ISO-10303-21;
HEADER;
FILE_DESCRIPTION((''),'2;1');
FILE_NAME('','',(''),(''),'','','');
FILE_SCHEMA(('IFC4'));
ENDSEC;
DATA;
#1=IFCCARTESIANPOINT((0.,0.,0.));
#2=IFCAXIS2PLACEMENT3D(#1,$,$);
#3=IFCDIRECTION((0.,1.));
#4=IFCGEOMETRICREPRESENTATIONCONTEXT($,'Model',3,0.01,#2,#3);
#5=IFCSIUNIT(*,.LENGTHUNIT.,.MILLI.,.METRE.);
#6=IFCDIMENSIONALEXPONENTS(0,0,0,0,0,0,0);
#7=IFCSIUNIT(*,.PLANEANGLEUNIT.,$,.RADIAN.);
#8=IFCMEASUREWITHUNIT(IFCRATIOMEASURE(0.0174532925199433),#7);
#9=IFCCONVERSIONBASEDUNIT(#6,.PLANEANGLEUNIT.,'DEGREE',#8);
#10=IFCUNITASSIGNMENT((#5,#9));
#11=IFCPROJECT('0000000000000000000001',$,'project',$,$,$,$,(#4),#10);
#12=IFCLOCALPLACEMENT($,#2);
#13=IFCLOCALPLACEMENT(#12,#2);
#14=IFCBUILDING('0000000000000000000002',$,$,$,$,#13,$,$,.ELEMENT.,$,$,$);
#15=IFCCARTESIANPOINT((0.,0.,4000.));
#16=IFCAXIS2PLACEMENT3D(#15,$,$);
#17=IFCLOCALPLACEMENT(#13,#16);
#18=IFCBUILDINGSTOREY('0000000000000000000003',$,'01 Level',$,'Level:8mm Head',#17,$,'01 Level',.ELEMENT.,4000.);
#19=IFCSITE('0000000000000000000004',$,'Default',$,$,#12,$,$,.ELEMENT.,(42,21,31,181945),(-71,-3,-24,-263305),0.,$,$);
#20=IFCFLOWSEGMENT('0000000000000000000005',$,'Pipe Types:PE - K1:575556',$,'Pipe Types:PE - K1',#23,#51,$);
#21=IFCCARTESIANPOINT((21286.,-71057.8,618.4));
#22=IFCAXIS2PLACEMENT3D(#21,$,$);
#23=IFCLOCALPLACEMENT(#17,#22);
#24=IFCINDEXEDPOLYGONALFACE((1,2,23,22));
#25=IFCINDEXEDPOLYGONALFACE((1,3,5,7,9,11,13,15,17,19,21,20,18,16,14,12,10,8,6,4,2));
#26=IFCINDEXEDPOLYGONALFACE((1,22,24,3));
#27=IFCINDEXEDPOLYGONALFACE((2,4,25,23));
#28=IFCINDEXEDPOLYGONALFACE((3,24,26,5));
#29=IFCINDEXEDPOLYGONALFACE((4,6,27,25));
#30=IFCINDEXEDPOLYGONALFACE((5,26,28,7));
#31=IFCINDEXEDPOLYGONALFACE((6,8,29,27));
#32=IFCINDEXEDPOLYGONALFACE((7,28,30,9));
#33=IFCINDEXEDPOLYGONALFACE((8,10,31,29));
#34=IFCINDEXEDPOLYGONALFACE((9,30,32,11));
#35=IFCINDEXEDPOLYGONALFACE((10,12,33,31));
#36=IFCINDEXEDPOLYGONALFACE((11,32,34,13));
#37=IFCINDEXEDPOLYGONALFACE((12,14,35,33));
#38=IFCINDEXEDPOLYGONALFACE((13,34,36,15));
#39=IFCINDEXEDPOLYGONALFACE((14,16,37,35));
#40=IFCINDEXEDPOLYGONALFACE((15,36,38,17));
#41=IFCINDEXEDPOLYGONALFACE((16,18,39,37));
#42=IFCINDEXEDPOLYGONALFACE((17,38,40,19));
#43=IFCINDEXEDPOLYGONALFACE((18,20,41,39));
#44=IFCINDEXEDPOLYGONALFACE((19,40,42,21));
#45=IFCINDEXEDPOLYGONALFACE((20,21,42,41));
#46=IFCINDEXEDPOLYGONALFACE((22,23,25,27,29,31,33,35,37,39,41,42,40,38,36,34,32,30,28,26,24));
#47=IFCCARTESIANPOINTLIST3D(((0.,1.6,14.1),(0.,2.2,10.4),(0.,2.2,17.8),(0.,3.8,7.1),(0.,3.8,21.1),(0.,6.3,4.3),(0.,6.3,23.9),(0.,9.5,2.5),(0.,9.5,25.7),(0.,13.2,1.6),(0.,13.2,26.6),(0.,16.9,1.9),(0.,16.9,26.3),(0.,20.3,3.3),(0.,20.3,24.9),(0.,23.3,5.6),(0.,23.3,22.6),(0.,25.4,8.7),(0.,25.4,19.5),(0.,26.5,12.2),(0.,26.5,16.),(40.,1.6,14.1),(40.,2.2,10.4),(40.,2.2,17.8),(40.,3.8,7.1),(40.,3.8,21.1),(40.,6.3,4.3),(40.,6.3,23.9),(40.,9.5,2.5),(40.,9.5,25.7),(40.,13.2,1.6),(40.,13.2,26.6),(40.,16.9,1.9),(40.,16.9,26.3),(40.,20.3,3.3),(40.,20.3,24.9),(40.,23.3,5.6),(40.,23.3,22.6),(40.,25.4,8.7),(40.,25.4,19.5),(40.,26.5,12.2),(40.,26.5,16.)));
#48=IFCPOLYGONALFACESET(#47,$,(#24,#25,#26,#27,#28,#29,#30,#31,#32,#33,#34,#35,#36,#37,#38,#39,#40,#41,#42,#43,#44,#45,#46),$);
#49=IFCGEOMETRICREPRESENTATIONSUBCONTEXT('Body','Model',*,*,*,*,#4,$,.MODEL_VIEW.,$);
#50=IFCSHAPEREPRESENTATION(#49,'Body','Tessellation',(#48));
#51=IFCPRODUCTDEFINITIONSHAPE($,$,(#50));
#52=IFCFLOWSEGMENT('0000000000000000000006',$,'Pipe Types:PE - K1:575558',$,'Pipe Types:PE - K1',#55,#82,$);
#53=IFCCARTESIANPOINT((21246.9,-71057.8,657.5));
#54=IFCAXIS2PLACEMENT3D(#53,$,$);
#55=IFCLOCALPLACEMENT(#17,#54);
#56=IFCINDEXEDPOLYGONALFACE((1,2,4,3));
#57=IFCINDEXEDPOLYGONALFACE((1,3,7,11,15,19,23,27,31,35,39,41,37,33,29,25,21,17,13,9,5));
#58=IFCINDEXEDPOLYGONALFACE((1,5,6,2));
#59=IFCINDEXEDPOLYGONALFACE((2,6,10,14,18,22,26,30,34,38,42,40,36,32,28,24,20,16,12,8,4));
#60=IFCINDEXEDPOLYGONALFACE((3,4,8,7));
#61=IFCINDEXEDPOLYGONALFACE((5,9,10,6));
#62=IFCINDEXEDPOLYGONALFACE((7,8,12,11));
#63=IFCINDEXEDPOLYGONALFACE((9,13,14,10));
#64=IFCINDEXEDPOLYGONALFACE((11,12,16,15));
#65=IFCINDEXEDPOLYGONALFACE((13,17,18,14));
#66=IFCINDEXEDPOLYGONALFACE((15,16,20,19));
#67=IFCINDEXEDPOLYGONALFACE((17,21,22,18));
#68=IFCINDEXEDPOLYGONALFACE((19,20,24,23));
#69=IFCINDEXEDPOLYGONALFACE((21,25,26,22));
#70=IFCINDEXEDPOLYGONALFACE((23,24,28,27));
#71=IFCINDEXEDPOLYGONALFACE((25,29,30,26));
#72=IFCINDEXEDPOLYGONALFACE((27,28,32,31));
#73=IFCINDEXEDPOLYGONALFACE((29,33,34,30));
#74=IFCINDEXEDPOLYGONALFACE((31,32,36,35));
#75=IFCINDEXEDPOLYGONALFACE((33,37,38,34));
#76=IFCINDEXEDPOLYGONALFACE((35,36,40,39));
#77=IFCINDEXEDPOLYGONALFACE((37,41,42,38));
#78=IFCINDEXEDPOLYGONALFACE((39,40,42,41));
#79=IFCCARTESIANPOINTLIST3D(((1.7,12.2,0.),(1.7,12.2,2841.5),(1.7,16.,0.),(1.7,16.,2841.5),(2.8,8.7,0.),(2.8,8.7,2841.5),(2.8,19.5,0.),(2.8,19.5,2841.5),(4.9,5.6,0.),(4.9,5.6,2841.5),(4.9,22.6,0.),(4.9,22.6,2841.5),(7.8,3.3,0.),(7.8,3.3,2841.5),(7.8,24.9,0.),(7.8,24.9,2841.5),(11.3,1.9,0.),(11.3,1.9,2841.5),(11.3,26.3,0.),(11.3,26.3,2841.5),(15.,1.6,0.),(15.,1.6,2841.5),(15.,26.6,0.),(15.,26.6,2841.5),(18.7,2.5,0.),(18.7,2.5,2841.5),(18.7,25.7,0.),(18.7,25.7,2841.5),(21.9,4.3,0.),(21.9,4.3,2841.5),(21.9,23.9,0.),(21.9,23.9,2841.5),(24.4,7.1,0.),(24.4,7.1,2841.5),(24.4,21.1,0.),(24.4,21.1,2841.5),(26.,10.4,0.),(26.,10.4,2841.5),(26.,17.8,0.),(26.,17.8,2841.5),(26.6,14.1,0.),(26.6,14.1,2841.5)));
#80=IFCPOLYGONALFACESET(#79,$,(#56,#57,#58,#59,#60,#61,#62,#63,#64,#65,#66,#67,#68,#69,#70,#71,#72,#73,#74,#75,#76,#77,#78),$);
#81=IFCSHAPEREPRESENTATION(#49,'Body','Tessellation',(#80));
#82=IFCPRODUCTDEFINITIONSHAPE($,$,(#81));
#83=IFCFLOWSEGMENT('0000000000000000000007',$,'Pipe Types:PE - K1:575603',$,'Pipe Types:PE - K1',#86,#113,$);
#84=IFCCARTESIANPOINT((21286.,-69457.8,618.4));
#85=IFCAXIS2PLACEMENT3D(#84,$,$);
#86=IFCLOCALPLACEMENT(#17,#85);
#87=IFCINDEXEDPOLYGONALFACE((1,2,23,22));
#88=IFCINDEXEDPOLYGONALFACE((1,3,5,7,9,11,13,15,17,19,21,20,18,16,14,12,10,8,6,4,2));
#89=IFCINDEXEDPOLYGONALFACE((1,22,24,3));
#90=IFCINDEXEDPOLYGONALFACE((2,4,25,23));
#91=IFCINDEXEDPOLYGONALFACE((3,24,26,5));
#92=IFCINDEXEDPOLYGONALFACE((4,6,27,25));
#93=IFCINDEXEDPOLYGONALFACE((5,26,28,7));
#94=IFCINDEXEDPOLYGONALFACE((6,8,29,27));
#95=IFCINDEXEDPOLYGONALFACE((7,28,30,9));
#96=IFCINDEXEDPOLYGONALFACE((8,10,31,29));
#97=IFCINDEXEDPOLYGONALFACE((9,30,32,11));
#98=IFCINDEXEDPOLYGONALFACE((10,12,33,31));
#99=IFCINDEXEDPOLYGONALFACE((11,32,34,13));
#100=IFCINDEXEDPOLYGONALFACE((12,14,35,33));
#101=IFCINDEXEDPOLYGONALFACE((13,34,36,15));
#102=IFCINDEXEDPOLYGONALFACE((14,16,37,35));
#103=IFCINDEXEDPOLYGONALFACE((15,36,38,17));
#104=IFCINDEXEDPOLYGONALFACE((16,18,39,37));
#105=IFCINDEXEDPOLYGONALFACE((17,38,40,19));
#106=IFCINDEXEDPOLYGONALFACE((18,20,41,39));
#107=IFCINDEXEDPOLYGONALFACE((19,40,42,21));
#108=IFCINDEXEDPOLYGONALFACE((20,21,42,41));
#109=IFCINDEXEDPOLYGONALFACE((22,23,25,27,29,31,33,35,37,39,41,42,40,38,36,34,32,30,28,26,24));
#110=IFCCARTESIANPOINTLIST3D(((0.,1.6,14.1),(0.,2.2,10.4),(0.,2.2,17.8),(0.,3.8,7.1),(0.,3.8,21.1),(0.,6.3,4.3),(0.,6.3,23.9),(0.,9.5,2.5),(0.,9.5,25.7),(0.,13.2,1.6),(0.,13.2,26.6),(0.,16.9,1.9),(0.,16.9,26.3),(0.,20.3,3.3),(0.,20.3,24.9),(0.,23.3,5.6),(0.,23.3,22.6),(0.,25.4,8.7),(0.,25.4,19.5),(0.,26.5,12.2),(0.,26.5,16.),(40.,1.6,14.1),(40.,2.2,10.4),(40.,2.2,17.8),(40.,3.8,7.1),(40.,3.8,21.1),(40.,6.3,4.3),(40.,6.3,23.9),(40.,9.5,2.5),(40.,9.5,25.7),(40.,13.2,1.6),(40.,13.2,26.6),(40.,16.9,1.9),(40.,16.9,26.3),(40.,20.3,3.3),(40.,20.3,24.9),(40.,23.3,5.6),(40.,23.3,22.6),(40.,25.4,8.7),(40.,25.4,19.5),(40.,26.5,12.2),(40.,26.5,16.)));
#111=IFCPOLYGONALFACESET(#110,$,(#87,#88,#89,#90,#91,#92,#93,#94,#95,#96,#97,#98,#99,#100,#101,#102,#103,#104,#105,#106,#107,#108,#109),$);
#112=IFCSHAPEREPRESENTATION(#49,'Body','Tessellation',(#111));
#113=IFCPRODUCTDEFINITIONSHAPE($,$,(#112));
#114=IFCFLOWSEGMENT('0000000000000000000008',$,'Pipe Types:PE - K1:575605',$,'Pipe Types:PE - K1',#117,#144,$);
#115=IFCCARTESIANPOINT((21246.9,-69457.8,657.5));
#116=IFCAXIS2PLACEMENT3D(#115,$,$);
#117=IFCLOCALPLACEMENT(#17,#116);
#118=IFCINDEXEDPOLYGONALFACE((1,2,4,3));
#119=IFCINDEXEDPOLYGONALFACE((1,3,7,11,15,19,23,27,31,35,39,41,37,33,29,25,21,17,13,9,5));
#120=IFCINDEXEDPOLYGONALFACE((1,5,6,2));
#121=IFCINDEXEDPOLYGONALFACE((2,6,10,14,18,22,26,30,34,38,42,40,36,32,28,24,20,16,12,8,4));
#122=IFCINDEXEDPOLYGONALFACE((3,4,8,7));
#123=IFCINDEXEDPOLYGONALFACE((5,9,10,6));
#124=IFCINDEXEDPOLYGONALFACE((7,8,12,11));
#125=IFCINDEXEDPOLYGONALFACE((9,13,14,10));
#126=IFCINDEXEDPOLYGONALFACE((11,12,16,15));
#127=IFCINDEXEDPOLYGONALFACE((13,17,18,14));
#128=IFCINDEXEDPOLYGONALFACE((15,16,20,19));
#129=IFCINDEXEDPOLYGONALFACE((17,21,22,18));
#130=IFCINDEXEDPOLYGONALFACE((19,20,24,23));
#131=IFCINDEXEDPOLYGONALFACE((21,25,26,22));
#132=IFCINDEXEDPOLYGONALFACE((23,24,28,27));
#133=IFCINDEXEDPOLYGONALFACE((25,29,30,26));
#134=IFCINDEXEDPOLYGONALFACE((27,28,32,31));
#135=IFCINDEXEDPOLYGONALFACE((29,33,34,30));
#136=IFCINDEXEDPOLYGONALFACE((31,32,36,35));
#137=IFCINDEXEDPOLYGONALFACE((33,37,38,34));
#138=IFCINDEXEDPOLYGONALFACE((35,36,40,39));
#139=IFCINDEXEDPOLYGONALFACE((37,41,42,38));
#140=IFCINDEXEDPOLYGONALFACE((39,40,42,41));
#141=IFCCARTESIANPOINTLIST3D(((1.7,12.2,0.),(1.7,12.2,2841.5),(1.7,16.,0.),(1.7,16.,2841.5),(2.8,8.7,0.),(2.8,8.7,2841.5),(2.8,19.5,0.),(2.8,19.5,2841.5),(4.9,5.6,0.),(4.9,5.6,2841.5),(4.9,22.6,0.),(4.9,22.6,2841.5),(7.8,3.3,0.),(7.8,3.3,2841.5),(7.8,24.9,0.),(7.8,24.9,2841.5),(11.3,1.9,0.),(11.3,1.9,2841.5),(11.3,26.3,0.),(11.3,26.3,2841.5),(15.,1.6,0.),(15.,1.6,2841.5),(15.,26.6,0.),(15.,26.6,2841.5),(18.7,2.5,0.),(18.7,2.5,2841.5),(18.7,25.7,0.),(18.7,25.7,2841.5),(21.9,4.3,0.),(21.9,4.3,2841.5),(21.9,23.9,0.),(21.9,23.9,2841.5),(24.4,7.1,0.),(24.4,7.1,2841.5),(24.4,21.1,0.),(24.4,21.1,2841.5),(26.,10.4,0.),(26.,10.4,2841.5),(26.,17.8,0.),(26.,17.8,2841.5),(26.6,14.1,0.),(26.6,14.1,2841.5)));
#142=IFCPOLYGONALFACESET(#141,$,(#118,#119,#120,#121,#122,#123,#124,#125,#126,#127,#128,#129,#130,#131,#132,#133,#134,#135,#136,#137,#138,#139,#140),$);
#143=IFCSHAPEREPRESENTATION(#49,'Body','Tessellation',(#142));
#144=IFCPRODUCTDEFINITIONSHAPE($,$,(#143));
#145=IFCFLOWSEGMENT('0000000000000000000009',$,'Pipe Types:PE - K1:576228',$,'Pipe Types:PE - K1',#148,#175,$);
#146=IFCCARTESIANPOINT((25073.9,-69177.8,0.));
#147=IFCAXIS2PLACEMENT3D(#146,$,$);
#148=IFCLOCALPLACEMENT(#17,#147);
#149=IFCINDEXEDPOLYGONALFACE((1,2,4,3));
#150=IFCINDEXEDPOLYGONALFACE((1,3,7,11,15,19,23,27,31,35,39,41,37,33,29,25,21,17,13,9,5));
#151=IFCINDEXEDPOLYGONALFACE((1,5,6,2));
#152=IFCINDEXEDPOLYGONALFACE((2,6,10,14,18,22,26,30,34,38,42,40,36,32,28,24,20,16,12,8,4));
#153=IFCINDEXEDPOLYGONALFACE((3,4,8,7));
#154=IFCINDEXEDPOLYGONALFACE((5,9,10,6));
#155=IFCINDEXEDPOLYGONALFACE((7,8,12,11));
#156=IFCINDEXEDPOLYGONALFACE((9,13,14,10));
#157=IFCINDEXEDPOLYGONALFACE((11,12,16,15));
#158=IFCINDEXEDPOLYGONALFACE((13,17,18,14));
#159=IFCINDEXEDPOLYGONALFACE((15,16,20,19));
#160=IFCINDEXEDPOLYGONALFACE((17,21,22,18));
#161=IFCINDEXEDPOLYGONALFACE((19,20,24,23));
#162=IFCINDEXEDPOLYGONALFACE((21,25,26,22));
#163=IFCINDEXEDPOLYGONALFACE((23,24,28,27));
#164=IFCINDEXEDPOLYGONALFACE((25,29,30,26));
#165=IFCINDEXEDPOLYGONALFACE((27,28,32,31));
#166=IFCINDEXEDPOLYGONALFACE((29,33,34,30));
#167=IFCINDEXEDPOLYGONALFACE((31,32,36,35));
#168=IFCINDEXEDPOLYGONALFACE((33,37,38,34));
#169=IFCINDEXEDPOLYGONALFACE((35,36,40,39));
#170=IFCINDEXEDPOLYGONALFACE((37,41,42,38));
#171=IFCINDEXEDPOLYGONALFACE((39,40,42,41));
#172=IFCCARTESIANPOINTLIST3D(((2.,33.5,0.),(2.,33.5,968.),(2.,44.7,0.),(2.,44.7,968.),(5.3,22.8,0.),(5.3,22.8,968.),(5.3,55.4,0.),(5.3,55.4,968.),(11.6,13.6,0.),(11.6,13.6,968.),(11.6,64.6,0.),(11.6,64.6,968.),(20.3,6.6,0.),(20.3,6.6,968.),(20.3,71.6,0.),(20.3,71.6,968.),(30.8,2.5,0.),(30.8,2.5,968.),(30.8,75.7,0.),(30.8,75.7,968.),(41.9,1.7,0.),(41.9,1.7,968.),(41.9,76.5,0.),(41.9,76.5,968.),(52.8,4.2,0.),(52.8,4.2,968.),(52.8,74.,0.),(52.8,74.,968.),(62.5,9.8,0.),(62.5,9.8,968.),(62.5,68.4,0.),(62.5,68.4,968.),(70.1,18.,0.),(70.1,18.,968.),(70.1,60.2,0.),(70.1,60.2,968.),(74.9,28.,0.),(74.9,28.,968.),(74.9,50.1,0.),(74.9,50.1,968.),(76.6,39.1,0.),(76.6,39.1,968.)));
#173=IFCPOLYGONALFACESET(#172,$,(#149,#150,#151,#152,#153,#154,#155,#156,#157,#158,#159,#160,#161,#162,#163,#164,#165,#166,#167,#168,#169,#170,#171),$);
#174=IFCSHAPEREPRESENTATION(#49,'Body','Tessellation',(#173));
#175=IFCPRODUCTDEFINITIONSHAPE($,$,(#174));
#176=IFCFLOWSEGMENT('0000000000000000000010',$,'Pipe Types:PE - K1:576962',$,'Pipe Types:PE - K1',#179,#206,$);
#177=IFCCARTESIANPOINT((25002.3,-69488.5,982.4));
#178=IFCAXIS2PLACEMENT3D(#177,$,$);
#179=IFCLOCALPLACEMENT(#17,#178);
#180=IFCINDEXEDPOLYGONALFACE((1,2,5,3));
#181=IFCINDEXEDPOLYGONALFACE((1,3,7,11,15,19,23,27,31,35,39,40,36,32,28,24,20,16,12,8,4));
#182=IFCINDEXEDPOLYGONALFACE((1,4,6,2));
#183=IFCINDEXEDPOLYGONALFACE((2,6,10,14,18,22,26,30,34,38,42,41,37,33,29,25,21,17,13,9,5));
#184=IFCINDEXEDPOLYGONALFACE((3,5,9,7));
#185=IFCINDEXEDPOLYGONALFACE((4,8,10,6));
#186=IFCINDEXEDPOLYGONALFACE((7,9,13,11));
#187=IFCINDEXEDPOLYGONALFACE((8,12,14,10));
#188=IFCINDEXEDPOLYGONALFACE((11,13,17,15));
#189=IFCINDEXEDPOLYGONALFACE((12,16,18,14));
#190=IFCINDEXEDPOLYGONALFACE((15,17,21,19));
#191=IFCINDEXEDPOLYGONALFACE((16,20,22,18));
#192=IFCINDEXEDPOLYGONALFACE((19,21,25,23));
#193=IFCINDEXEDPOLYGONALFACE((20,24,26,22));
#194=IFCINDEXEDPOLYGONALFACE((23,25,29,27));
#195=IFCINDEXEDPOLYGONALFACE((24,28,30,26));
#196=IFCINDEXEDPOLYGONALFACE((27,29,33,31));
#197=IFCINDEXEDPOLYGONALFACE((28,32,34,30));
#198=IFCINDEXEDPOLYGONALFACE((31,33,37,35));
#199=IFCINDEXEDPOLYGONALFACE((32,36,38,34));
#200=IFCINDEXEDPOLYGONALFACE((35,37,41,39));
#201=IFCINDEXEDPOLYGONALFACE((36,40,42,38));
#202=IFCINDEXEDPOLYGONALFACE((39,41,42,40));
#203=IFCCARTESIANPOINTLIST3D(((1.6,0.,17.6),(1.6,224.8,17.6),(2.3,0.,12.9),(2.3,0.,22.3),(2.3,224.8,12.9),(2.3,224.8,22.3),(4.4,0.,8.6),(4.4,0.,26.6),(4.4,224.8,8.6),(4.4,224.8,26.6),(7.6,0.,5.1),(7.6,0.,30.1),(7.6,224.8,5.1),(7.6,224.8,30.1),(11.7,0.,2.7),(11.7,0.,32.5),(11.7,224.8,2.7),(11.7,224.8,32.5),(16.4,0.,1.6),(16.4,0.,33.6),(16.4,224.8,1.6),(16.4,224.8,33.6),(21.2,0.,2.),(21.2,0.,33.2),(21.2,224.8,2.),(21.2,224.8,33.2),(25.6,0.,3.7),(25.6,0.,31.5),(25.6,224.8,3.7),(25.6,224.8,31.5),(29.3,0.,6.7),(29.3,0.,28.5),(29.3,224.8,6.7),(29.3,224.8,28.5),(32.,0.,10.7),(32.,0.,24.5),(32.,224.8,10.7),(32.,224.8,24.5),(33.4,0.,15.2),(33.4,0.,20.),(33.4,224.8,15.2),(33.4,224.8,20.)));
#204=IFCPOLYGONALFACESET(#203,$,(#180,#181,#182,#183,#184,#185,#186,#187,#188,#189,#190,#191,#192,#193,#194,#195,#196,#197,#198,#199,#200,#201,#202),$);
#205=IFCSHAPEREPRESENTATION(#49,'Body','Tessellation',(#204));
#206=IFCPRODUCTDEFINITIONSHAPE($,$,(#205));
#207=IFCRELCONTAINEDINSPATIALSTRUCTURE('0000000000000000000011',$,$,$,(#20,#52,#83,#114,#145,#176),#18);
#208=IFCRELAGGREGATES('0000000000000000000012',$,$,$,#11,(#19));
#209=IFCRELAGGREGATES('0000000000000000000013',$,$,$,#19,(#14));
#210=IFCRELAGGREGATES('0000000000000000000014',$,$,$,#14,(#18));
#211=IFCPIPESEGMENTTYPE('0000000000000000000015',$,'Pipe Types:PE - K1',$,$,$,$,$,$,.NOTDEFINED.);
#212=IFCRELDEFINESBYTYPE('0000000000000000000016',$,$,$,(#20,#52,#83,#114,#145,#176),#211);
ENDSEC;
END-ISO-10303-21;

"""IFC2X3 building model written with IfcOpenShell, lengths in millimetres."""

from ifc_helpers import new_model, entity, si_unit, converted_unit, direction, frame, frame_2d, origin, origin_2d_with_axis, place, context, subcontext, project, spatial, circle, extrude, type_object, element, save


model = new_model("IFC2X3")

# Units and contexts
model_context = context("Model", 3, precision=0.01, world=origin(), true_north=direction((0.0, 1.0)))
body_context = subcontext(model_context, "Body", "Model", "MODEL_VIEW")
ifc_project = project(units=[si_unit("LENGTHUNIT", "METRE", prefix="MILLI"), converted_unit("PLANEANGLEUNIT", "DEGREE", entity("IfcRatioMeasure", 0.0174532925199433), si_unit("PLANEANGLEUNIT", "RADIAN"), dimensions=[0, 0, 0, 0, 0, 0, 0])], contexts=[model_context])

# Site, building, storey
site_placement = place(None, origin())
site = spatial("IfcSite", under=ifc_project, at=site_placement, Name="Default", CompositionType="ELEMENT", RefLatitude=(42, 21, 31, 181945), RefLongitude=(-71, -3, -24, -263305), RefElevation=0.0)
building_placement = place(site_placement, origin())
building = spatial("IfcBuilding", under=site, at=building_placement, CompositionType="ELEMENT")
storey_placement = place(building_placement, frame((0.0, 0.0, 4000.0)))
storey = spatial("IfcBuildingStorey", under=building, at=storey_placement, Name="01 Level", ObjectType="Level:8mm Head", LongName="01 Level", CompositionType="ELEMENT", Elevation=4000.0)

# Flow segments
pipe_segment_type = type_object("IfcPipeSegmentType", Name="Pipe Types:PE - K1", PredefinedType="NOTDEFINED")
flow_segment_1_placement = place(storey_placement, frame((21286.0, -71057.8, 618.4)))
element("IfcFlowSegment", 1, at=flow_segment_1_placement, inside=storey, type_object=pipe_segment_type, Name="Pipe Types:PE - K1:575556", ObjectType="Pipe Types:PE - K1", context=body_context, shape_type="SweptSolid", body=[
    extrude(circle(Radius=12.5, at=origin_2d_with_axis()), frame((0.0, 14.1, 14.1), z_axis=(1.0, 0.0, 0.0), x_axis=(0.0, -1.0, 0.0)), (0.0, 0.0, 1.0), 40.0),
])
flow_segment_2_placement = place(storey_placement, frame((21246.9, -71057.8, 657.5)))
element("IfcFlowSegment", 2, at=flow_segment_2_placement, inside=storey, type_object=pipe_segment_type, Name="Pipe Types:PE - K1:575558", ObjectType="Pipe Types:PE - K1", context=body_context, shape_type="SweptSolid", body=[
    extrude(circle(Radius=12.5, at=frame_2d((0.0, 0.0), x_axis=(1.0, 0.0))), frame((14.1, 14.1, 0.0)), (0.0, 0.0, 1.0), 2841.5),
])
flow_segment_3_placement = place(storey_placement, frame((21286.0, -69457.8, 618.4)))
element("IfcFlowSegment", 3, at=flow_segment_3_placement, inside=storey, type_object=pipe_segment_type, Name="Pipe Types:PE - K1:575603", ObjectType="Pipe Types:PE - K1", context=body_context, shape_type="SweptSolid", body=[
    extrude(circle(Radius=12.5, at=origin_2d_with_axis()), frame((0.0, 14.1, 14.1), z_axis=(1.0, 0.0, 0.0), x_axis=(0.0, -1.0, 0.0)), (0.0, 0.0, 1.0), 40.0),
])
flow_segment_4_placement = place(storey_placement, frame((21246.9, -69457.8, 657.5)))
element("IfcFlowSegment", 4, at=flow_segment_4_placement, inside=storey, type_object=pipe_segment_type, Name="Pipe Types:PE - K1:575605", ObjectType="Pipe Types:PE - K1", context=body_context, shape_type="SweptSolid", body=[
    extrude(circle(Radius=12.5, at=origin_2d_with_axis()), frame((14.1, 14.1, 0.0)), (0.0, 0.0, 1.0), 2841.5),
])
flow_segment_5_placement = place(storey_placement, frame((25073.9, -69177.8, 0.0)))
element("IfcFlowSegment", 5, at=flow_segment_5_placement, inside=storey, type_object=pipe_segment_type, Name="Pipe Types:PE - K1:576228", ObjectType="Pipe Types:PE - K1", context=body_context, shape_type="SweptSolid", body=[
    extrude(circle(Radius=37.5, at=origin_2d_with_axis()), frame((39.1, 39.1, 0.0)), (0.0, 0.0, 1.0), 968.0),
])
flow_segment_6_placement = place(storey_placement, frame((25002.3, -69488.5, 982.4)))
element("IfcFlowSegment", 6, at=flow_segment_6_placement, inside=storey, type_object=pipe_segment_type, Name="Pipe Types:PE - K1:576962", ObjectType="Pipe Types:PE - K1", context=body_context, shape_type="SweptSolid", body=[
    extrude(circle(Radius=16.0, at=origin_2d_with_axis()), frame((17.6, 0.0, 17.6), z_axis=(0.0, 1.0, 0.0), x_axis=(-1.0, 0.0, 0.0)), (0.0, 0.0, 1.0), 224.8),
])

save(model, "model.ifc")
